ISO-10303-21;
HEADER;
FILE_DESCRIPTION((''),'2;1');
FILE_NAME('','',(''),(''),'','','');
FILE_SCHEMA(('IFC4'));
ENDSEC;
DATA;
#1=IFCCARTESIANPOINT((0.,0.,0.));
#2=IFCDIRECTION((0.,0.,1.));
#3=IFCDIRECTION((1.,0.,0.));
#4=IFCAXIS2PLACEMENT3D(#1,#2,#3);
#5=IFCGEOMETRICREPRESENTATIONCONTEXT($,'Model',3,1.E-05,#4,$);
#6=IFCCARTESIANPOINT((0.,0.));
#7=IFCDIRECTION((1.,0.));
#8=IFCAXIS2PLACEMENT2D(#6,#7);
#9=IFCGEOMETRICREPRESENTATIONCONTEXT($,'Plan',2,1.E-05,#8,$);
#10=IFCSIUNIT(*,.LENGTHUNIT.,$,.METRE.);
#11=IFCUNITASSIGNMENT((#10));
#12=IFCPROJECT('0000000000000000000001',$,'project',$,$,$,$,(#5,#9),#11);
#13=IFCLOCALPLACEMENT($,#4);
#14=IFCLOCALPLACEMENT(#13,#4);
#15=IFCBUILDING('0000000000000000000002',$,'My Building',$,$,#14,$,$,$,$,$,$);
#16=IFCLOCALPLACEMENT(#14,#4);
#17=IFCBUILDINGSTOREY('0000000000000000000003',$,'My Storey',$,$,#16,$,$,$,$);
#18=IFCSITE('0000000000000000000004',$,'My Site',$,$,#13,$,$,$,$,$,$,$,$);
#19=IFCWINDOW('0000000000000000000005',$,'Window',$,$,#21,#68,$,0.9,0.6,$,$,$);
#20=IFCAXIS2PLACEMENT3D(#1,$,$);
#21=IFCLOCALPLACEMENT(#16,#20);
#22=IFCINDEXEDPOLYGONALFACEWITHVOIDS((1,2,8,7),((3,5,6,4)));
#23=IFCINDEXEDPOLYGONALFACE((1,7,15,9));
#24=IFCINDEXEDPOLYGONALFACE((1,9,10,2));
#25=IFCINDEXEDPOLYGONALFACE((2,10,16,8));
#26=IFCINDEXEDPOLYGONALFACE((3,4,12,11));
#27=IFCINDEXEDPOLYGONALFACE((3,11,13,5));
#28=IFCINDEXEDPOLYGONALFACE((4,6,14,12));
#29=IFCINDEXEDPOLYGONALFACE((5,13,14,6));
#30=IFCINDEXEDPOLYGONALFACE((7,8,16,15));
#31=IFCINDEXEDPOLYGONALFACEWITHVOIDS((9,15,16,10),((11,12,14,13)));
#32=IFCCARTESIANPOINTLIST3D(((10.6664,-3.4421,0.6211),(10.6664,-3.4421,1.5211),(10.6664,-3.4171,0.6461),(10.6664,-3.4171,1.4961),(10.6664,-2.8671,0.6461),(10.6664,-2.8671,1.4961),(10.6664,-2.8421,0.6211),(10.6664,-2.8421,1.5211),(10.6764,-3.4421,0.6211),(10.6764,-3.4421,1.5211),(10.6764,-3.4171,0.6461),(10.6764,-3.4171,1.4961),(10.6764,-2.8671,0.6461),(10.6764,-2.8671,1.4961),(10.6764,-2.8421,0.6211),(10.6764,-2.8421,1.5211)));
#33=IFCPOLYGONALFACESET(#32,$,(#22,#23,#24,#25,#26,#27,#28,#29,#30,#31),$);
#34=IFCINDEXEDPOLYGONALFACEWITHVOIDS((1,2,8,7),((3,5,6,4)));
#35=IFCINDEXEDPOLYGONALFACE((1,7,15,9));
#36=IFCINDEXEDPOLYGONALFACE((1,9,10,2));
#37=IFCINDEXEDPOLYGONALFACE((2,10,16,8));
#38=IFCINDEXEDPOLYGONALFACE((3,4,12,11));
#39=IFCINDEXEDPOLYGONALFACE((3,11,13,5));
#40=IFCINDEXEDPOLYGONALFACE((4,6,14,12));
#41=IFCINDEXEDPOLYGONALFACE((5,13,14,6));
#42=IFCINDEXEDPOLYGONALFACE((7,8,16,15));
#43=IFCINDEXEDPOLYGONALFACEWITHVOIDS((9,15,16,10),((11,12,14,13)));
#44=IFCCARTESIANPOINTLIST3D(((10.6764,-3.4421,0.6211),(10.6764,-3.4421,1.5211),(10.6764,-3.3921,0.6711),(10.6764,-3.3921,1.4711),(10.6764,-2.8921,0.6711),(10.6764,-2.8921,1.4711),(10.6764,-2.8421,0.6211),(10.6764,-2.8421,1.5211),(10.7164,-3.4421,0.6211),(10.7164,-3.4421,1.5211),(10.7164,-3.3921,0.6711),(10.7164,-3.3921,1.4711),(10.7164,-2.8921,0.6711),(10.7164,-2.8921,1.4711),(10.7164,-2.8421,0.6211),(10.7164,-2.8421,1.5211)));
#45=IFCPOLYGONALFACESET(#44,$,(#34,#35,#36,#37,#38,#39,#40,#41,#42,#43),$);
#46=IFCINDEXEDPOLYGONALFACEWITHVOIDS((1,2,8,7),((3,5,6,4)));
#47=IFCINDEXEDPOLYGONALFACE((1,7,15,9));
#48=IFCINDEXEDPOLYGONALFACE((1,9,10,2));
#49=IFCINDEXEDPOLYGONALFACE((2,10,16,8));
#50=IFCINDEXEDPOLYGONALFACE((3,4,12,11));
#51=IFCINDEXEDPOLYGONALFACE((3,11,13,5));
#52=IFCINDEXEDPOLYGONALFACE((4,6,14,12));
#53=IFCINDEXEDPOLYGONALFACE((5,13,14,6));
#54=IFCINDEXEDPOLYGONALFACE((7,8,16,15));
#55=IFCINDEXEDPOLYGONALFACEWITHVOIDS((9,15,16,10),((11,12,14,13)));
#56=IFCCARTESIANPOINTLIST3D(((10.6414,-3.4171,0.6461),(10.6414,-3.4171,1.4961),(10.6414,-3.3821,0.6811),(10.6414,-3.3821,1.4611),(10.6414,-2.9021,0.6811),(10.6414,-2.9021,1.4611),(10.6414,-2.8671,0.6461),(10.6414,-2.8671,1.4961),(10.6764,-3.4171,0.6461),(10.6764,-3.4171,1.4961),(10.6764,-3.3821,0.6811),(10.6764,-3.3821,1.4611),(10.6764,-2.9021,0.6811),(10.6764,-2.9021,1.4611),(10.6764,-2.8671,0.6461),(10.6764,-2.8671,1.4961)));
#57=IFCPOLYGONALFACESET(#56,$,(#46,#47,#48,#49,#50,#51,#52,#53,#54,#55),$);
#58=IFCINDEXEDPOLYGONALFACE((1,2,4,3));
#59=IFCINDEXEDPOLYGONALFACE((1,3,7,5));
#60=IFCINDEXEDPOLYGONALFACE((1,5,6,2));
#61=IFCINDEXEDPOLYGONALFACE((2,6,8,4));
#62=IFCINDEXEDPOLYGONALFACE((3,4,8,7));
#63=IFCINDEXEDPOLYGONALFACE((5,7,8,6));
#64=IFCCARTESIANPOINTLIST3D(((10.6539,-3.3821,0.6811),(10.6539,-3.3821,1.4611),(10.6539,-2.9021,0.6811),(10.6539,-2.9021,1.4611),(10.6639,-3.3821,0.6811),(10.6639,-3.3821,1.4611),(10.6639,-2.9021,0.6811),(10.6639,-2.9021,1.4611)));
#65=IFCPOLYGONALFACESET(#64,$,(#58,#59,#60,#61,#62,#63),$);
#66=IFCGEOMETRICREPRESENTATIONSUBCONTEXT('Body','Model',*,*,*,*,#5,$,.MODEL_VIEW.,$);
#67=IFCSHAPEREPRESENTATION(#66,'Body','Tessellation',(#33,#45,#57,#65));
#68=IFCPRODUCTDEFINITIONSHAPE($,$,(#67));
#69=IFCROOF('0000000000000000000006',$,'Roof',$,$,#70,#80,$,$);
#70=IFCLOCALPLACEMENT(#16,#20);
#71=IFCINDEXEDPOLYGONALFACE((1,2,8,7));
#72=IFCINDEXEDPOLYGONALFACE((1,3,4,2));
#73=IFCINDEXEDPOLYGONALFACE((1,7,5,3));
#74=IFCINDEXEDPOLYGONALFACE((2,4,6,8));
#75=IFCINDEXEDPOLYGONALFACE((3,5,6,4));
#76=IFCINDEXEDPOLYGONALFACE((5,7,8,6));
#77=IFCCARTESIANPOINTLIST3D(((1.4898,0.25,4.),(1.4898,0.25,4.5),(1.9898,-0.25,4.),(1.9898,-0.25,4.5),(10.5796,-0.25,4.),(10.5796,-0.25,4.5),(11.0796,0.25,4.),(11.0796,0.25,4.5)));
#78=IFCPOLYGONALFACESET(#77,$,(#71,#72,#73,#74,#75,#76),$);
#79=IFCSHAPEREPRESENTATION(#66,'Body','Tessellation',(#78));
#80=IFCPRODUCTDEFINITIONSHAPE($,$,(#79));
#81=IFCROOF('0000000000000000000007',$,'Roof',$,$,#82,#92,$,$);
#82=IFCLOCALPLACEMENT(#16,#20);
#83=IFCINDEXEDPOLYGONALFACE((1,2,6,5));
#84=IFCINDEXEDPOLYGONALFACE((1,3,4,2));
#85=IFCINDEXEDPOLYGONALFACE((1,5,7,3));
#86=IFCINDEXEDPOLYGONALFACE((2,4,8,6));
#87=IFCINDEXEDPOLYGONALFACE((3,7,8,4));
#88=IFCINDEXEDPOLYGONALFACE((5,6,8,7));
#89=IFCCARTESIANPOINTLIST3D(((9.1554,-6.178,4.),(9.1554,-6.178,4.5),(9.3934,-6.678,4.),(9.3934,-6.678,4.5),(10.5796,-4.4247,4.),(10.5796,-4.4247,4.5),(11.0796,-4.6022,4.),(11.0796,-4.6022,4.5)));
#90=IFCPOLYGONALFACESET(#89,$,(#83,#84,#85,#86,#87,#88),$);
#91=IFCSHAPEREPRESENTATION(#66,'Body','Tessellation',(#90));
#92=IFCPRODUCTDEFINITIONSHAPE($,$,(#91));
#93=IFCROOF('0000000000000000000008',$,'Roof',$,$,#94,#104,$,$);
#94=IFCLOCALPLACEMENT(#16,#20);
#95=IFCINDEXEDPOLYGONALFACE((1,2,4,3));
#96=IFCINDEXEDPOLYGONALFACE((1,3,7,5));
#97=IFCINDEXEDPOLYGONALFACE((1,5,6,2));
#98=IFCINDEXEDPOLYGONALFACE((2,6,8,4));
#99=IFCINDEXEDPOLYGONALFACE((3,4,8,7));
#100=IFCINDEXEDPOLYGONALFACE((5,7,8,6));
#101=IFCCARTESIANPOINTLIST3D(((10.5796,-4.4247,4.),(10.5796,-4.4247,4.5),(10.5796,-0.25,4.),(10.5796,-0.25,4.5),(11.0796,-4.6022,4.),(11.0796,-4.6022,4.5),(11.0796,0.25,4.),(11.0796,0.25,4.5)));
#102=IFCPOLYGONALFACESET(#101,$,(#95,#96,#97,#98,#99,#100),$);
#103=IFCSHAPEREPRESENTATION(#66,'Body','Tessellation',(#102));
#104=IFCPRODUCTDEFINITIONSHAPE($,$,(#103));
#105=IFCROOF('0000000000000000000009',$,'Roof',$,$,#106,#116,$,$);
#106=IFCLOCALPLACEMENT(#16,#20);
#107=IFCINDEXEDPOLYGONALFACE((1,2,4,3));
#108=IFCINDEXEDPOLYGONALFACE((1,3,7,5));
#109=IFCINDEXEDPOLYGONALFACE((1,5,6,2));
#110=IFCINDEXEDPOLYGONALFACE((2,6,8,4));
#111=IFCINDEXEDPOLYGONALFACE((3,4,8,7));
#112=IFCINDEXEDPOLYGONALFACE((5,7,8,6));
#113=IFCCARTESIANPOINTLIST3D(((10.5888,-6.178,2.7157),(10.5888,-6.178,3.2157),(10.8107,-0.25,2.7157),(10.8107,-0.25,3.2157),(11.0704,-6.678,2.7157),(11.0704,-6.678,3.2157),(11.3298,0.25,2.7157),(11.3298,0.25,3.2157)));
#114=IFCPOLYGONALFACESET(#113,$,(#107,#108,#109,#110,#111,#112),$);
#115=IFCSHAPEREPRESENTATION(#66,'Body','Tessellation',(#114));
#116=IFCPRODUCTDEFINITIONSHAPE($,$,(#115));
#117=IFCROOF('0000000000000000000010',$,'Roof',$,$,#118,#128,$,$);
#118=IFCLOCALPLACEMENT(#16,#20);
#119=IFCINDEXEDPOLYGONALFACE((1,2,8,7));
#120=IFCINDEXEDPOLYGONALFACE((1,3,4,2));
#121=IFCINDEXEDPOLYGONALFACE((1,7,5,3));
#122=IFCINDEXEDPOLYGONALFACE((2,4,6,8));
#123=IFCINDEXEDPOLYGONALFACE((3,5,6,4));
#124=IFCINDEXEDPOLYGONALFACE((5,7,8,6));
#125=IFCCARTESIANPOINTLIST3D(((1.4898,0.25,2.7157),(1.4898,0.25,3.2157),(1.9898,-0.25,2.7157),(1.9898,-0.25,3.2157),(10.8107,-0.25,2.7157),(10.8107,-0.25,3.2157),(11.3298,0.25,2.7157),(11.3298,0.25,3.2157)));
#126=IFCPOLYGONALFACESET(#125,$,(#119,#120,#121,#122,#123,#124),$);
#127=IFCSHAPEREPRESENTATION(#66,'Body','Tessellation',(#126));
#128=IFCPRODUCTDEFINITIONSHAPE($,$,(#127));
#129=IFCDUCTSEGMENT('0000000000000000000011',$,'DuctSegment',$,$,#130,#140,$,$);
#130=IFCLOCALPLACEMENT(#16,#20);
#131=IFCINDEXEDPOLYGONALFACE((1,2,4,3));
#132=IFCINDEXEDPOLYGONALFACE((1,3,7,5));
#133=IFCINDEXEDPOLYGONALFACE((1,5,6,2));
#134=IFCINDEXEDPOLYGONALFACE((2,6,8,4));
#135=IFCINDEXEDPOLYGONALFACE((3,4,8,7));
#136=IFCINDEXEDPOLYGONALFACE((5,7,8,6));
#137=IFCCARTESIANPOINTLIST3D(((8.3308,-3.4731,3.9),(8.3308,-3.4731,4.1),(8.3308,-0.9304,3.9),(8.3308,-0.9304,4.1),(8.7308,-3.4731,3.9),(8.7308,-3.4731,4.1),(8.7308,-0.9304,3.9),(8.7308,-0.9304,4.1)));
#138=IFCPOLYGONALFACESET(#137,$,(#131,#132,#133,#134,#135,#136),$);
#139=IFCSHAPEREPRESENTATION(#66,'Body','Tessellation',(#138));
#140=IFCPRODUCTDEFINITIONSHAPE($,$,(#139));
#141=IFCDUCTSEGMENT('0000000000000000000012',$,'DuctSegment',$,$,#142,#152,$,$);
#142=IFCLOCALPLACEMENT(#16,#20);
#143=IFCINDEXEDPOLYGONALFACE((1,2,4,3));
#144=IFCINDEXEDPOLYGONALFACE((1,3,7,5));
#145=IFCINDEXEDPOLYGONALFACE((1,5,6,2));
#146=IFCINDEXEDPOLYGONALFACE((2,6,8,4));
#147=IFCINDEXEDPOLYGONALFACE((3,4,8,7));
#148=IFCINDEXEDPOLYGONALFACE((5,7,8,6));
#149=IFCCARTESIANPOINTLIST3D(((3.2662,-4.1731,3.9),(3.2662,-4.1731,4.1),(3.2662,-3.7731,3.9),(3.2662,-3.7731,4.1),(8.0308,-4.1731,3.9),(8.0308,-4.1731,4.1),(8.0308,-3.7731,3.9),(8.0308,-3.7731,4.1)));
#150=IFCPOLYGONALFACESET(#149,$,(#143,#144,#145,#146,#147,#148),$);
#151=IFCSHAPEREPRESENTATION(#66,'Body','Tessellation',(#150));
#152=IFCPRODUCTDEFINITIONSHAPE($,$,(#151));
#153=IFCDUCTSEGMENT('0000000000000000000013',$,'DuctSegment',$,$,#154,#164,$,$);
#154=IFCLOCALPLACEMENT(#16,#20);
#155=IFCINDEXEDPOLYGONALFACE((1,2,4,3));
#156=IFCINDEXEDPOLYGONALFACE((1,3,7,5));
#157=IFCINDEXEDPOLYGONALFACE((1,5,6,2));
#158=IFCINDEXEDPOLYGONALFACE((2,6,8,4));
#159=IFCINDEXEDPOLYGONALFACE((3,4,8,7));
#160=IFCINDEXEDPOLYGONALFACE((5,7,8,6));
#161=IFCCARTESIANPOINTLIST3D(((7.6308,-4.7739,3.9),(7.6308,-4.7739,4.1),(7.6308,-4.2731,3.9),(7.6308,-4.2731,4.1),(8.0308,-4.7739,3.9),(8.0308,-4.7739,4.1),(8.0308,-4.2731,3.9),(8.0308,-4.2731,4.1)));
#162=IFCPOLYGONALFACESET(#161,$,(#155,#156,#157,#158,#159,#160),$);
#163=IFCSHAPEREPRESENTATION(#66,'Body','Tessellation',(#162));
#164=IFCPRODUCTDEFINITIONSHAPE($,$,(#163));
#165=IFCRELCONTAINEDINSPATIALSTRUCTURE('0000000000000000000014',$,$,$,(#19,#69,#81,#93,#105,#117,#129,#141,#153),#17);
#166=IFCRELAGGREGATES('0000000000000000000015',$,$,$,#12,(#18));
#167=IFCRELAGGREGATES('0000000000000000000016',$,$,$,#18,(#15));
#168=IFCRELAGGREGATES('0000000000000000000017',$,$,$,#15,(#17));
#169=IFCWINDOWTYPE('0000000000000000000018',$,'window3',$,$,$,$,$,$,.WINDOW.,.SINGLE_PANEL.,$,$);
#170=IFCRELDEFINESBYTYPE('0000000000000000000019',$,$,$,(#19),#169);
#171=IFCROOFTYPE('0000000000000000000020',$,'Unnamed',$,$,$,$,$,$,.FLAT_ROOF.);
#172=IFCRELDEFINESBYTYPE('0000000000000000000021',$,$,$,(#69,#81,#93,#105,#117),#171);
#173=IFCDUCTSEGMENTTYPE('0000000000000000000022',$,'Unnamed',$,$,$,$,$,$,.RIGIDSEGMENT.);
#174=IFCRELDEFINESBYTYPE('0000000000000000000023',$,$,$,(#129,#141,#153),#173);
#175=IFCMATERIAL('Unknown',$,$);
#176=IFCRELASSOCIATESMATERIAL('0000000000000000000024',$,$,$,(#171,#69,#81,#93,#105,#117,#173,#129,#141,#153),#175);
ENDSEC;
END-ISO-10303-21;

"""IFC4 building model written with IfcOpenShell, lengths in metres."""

from ifc_helpers import new_model, entity, si_unit, frame, origin_with_axes, origin_2d_with_axis, place, context, subcontext, project, spatial, line, indexed_curve, rectangle, outline, extrude, clip, halfspace, shape, source, transform, mapped, material, material_profile, profile_set, profile_usage, type_object, type_shapes, element, save


model = new_model("IFC4")

# Units and contexts
model_context = context("Model", 3, precision=1e-05, world=origin_with_axes())
plan_context = context("Plan", 2, precision=1e-05, world=origin_2d_with_axis())
body_context_1 = subcontext(model_context, "Body", "Model", "MODEL_VIEW")
body_context_2 = subcontext(plan_context, "Body", "Plan", "PLAN_VIEW")
ifc_project = project(units=[si_unit("LENGTHUNIT", "METRE")], contexts=[model_context, plan_context])

# Site, building, storey
site_placement = place(None, origin_with_axes())
site = spatial("IfcSite", under=ifc_project, at=site_placement, Name="My Site")
building_placement = place(site_placement, origin_with_axes())
building = spatial("IfcBuilding", under=site, at=building_placement, Name="My Building")
storey_placement = place(building_placement, origin_with_axes())
storey = spatial("IfcBuildingStorey", under=building, at=storey_placement, Name="My Storey")

# Shared definitions
ifc_material = material(Name="Unknown")

# Window
window_type = type_object("IfcWindowType", Name="window3", PartitioningType="SINGLE_PANEL", PredefinedType="WINDOW")
shared_shape_1 = source(origin_with_axes(), body_context_1, "Body", "SweptSolid", [
    extrude(outline(indexed_curve([(0.0, 0.0), (0.6, 0.0), (0.6, 0.9), (0.0, 0.9)], segments=[line(1, 2, 3, 4, 1)]), holes=[indexed_curve([(0.025, 0.025), (0.575, 0.025), (0.575, 0.875), (0.025, 0.875)], segments=[line(1, 2, 3, 4, 1)])]), frame((0.0, 0.09, 0.0), z_axis=(0.0, -1.0, 0.0), x_axis=(1.0, 0.0, 0.0)), (0.0, 0.0, -1.0), 0.01),
    extrude(outline(indexed_curve([(0.0, 0.0), (0.6, 0.0), (0.6, 0.9), (0.0, 0.9)], segments=[line(1, 2, 3, 4, 1)]), holes=[indexed_curve([(0.05, 0.05), (0.55, 0.05), (0.55, 0.85), (0.05, 0.85)], segments=[line(1, 2, 3, 4, 1)])]), frame((0.0, 0.05, 0.0), z_axis=(0.0, -1.0, 0.0), x_axis=(1.0, 0.0, 0.0)), (0.0, 0.0, -1.0), 0.04),
    extrude(outline(indexed_curve([(0.0, 0.0), (0.55, 0.0), (0.55, 0.85), (0.0, 0.85)], segments=[line(1, 2, 3, 4, 1)]), holes=[indexed_curve([(0.035, 0.035), (0.515, 0.035), (0.515, 0.815), (0.035, 0.815)], segments=[line(1, 2, 3, 4, 1)])]), frame((0.025, 0.09, 0.025), z_axis=(0.0, -1.0, 0.0), x_axis=(1.0, 0.0, 0.0)), (0.0, 0.0, -1.0), 0.035),
    extrude(outline(indexed_curve([(0.035, 0.035), (0.515, 0.035), (0.515, 0.815), (0.035, 0.815)], segments=[line(1, 2, 3, 4, 1)])), frame((0.025, 0.1025, 0.025), z_axis=(0.0, -1.0, 0.0), x_axis=(1.0, 0.0, 0.0)), (0.0, 0.0, -1.0), 0.01),
])
shared_shape_2 = source(origin_with_axes(), body_context_2, "Body", "Curve2D", [
    entity("IfcIndexedPolyCurve", entity("IfcCartesianPointList2D", [[0.05, 0.05], [0.55, 0.05]])),
    entity("IfcIndexedPolyCurve", entity("IfcCartesianPointList2D", [[0.0, 0.1], [0.025, 0.1], [0.025, 0.09], [0.05, 0.09], [0.05, 0.05], [0.0, 0.05]]), [entity("IfcLineIndex", [1, 2, 3, 4, 5, 6, 1])]),
    entity("IfcIndexedPolyCurve", entity("IfcCartesianPointList2D", [[0.6, 0.1], [0.575, 0.1], [0.575, 0.09], [0.55, 0.09], [0.55, 0.05], [0.6, 0.05]]), [entity("IfcLineIndex", [1, 2, 3, 4, 5, 6, 1])]),
    entity("IfcIndexedPolyCurve", entity("IfcCartesianPointList2D", [[0.025, 0.09], [0.06, 0.09], [0.06, 0.125], [0.025, 0.125]]), [entity("IfcLineIndex", [1, 2, 3, 4, 1])]),
    entity("IfcIndexedPolyCurve", entity("IfcCartesianPointList2D", [[0.575, 0.09], [0.54, 0.09], [0.54, 0.125], [0.575, 0.125]]), [entity("IfcLineIndex", [1, 2, 3, 4, 1])]),
    entity("IfcIndexedPolyCurve", entity("IfcCartesianPointList2D", [[0.06, 0.09], [0.54, 0.09]])),
    entity("IfcIndexedPolyCurve", entity("IfcCartesianPointList2D", [[0.06, 0.125], [0.54, 0.125]])),
    entity("IfcIndexedPolyCurve", entity("IfcCartesianPointList2D", [[0.06, 0.1075], [0.54, 0.1075]])),
])
type_shapes(window_type, [shared_shape_1, shared_shape_2])
window_placement = place(storey_placement, frame((10.7664, -3.4421, 0.6211), z_axis=(0.0, 0.0, 1.0), x_axis=(0.0, 1.0, 0.0)))
element("IfcWindow", 1, at=window_placement, inside=storey, type_object=window_type, Name="Window", OverallHeight=0.9, OverallWidth=0.6, shapes=[
    shape(body_context_1, "Body", "MappedRepresentation", [mapped(shared_shape_1, transform((0.0, 0.0, 0.0), x_axis=(1.0, 0.0, 0.0), y_axis=(0.0, 1.0, 0.0), z_axis=(0.0, 0.0, 1.0), scale=1.0))]),
    shape(body_context_2, "Body", "MappedRepresentation", [mapped(shared_shape_2, transform((0.0, 0.0, 0.0), x_axis=(1.0, 0.0, 0.0), y_axis=(0.0, 1.0, 0.0), z_axis=(0.0, 0.0, 1.0), scale=1.0))]),
])

# Roofs
ifc_material_profile_1 = material_profile(ifc_material, rectangle(XDim=0.5, YDim=0.5))
ifc_profile_set_1 = profile_set([ifc_material_profile_1])
ifc_profile_usage_1 = profile_usage(ifc_profile_set_1, cardinal=5)
roof_type = type_object("IfcRoofType", Name="Unnamed", PredefinedType="FLAT_ROOF", material=ifc_profile_set_1)
roof_1_placement = place(storey_placement, frame((11.0796, 0.0, 4.25), z_axis=(-1.0, 0.0, 0.0), x_axis=(0.0, -1.0, 0.0)))
element("IfcRoof", 2, at=roof_1_placement, inside=storey, type_object=roof_type, material=ifc_profile_usage_1, Name="Roof", context=body_context_1, shape_type="Clipping", body=[
    clip(clip(extrude(rectangle(XDim=0.5, YDim=0.5), origin_with_axes(), (0.0, 0.0, 1.0), 9.5898), halfspace(frame((-0.25, -4.0, 9.5898), z_axis=(0.707107, 0.0, 0.707107), x_axis=(0.0, -1.0, 0.0)), False)), halfspace(frame((-0.25, -4.0, 0.0), z_axis=(0.707107, 0.0, -0.707107), x_axis=(0.0, -1.0, 0.0)), False)),
])
ifc_profile_usage_2 = profile_usage(ifc_profile_set_1, cardinal=5)
roof_2_placement = place(storey_placement, frame((8.7561, -7.0661, 4.25), z_axis=(0.630485, 0.776202, 0.0), x_axis=(-0.776202, 0.630485, 0.0)))
element("IfcRoof", 3, at=roof_2_placement, inside=storey, type_object=roof_type, material=ifc_profile_usage_2, Name="Roof", context=body_context_1, shape_type="Clipping", body=[
    clip(clip(extrude(rectangle(XDim=0.5, YDim=0.5), origin_with_axes(), (0.0, 0.0, 1.0), 4.1852), halfspace(frame((-0.25, -4.0, 0.7031), z_axis=(0.429832, 0.0, -0.902909), x_axis=(0.0, -1.0, 0.0)), False)), halfspace(frame((-0.25, -4.0, 3.3774), z_axis=(0.334508, 0.0, 0.942393), x_axis=(-0.000001, -1.0, 0.0)), False)),
])
ifc_profile_usage_3 = profile_usage(ifc_profile_set_1, cardinal=5)
roof_3_placement = place(storey_placement, frame((10.8296, -5.4099, 4.25), z_axis=(0.0, 1.0, 0.0), x_axis=(-1.0, 0.0, 0.0)))
element("IfcRoof", 4, at=roof_3_placement, inside=storey, type_object=roof_type, material=ifc_profile_usage_3, Name="Roof", context=body_context_1, shape_type="Clipping", body=[
    clip(clip(extrude(rectangle(XDim=0.5, YDim=0.5), origin_with_axes(), (0.0, 0.0, 1.0), 5.6599), halfspace(frame((-0.25, -4.0, 5.6599), z_axis=(0.707107, 0.0, 0.707107), x_axis=(0.0, -1.0, 0.0)), False)), halfspace(frame((-0.25, -4.0, 0.8078), z_axis=(0.334508, 0.0, -0.942393), x_axis=(0.000001, -1.0, 0.0)), False)),
])
ifc_profile_usage_4 = profile_usage(ifc_profile_set_1, cardinal=5)
roof_4_placement = place(storey_placement, frame((10.8015, -7.1776, 2.9657), z_axis=(0.03741, 0.9993, 0.0), x_axis=(-0.9993, 0.03741, 0.0)))
element("IfcRoof", 5, at=roof_4_placement, inside=storey, type_object=roof_type, material=ifc_profile_usage_4, Name="Roof", context=body_context_1, shape_type="Clipping", body=[
    clip(clip(extrude(rectangle(XDim=0.5, YDim=0.5), origin_with_axes(), (0.0, 0.0, 1.0), 7.9328), halfspace(frame((-0.25, -2.9657, 0.5094), z_axis=(0.693753, 0.0, -0.720213), x_axis=(0.0, -1.0, 0.0)), False)), halfspace(frame((-0.25, -2.9657, 7.4422), z_axis=(0.720211, 0.0, 0.693755), x_axis=(0.0, -1.0, 0.0)), False)),
])
ifc_profile_usage_5 = profile_usage(ifc_profile_set_1, cardinal=5)
roof_5_placement = place(storey_placement, frame((11.8204, 0.0, 2.9657), z_axis=(-1.0, 0.0, 0.0), x_axis=(0.0, -1.0, 0.0)))
element("IfcRoof", 6, at=roof_5_placement, inside=storey, type_object=roof_type, material=ifc_profile_usage_5, Name="Roof", context=body_context_1, shape_type="Clipping", body=[
    clip(clip(extrude(rectangle(XDim=0.5, YDim=0.5), origin_with_axes(), (0.0, 0.0, 1.0), 10.3306), halfspace(frame((-0.25, -2.9657, 0.4906), z_axis=(0.720213, 0.0, -0.693753), x_axis=(0.0, -1.0, 0.0)), False)), halfspace(frame((-0.25, -2.9657, 10.3306), z_axis=(0.707107, 0.0, 0.707107), x_axis=(0.0, -1.0, 0.0)), False)),
])

# Duct segments
ifc_material_profile_2 = material_profile(ifc_material, rectangle(XDim=0.4, YDim=0.2))
ifc_profile_set_2 = profile_set([ifc_material_profile_2])
ifc_profile_usage_6 = profile_usage(ifc_profile_set_2, cardinal=5)
duct_segment_type = type_object("IfcDuctSegmentType", Name="Unnamed", PredefinedType="RIGIDSEGMENT", material=ifc_profile_set_2)
duct_segment_1_placement = place(storey_placement, frame((8.5308, -0.9304, 4.0), z_axis=(0.0, -1.0, 0.0), x_axis=(1.0, 0.0, 0.0)))
element("IfcDuctSegment", 7, at=duct_segment_1_placement, inside=storey, type_object=duct_segment_type, material=ifc_profile_usage_6, Name="DuctSegment", context=body_context_1, shape_type="SweptSolid", body=[
    extrude(rectangle(XDim=0.4, YDim=0.2), origin_with_axes(), (0.0, 0.0, 1.0), 2.5426),
])
ifc_profile_usage_7 = profile_usage(ifc_profile_set_2, cardinal=5)
duct_segment_2_placement = place(storey_placement, frame((8.0308, -3.9731, 4.0), z_axis=(-1.0, 0.0, 0.0), x_axis=(0.0, -1.0, 0.0)))
element("IfcDuctSegment", 8, at=duct_segment_2_placement, inside=storey, type_object=duct_segment_type, material=ifc_profile_usage_7, Name="DuctSegment", context=body_context_1, shape_type="SweptSolid", body=[
    extrude(rectangle(XDim=0.4, YDim=0.2), origin_with_axes(), (0.0, 0.0, 1.0), 4.7646),
])
ifc_profile_usage_8 = profile_usage(ifc_profile_set_2, cardinal=5)
duct_segment_3_placement = place(storey_placement, frame((7.8308, -4.2731, 4.0), z_axis=(0.0, -1.0, 0.0), x_axis=(1.0, 0.0, 0.0)))
element("IfcDuctSegment", 9, at=duct_segment_3_placement, inside=storey, type_object=duct_segment_type, material=ifc_profile_usage_8, Name="DuctSegment", context=body_context_1, shape_type="SweptSolid", body=[
    extrude(rectangle(XDim=0.4, YDim=0.2), origin_with_axes(), (0.0, 0.0, 1.0), 0.5008),
])

save(model, "model.ifc")
